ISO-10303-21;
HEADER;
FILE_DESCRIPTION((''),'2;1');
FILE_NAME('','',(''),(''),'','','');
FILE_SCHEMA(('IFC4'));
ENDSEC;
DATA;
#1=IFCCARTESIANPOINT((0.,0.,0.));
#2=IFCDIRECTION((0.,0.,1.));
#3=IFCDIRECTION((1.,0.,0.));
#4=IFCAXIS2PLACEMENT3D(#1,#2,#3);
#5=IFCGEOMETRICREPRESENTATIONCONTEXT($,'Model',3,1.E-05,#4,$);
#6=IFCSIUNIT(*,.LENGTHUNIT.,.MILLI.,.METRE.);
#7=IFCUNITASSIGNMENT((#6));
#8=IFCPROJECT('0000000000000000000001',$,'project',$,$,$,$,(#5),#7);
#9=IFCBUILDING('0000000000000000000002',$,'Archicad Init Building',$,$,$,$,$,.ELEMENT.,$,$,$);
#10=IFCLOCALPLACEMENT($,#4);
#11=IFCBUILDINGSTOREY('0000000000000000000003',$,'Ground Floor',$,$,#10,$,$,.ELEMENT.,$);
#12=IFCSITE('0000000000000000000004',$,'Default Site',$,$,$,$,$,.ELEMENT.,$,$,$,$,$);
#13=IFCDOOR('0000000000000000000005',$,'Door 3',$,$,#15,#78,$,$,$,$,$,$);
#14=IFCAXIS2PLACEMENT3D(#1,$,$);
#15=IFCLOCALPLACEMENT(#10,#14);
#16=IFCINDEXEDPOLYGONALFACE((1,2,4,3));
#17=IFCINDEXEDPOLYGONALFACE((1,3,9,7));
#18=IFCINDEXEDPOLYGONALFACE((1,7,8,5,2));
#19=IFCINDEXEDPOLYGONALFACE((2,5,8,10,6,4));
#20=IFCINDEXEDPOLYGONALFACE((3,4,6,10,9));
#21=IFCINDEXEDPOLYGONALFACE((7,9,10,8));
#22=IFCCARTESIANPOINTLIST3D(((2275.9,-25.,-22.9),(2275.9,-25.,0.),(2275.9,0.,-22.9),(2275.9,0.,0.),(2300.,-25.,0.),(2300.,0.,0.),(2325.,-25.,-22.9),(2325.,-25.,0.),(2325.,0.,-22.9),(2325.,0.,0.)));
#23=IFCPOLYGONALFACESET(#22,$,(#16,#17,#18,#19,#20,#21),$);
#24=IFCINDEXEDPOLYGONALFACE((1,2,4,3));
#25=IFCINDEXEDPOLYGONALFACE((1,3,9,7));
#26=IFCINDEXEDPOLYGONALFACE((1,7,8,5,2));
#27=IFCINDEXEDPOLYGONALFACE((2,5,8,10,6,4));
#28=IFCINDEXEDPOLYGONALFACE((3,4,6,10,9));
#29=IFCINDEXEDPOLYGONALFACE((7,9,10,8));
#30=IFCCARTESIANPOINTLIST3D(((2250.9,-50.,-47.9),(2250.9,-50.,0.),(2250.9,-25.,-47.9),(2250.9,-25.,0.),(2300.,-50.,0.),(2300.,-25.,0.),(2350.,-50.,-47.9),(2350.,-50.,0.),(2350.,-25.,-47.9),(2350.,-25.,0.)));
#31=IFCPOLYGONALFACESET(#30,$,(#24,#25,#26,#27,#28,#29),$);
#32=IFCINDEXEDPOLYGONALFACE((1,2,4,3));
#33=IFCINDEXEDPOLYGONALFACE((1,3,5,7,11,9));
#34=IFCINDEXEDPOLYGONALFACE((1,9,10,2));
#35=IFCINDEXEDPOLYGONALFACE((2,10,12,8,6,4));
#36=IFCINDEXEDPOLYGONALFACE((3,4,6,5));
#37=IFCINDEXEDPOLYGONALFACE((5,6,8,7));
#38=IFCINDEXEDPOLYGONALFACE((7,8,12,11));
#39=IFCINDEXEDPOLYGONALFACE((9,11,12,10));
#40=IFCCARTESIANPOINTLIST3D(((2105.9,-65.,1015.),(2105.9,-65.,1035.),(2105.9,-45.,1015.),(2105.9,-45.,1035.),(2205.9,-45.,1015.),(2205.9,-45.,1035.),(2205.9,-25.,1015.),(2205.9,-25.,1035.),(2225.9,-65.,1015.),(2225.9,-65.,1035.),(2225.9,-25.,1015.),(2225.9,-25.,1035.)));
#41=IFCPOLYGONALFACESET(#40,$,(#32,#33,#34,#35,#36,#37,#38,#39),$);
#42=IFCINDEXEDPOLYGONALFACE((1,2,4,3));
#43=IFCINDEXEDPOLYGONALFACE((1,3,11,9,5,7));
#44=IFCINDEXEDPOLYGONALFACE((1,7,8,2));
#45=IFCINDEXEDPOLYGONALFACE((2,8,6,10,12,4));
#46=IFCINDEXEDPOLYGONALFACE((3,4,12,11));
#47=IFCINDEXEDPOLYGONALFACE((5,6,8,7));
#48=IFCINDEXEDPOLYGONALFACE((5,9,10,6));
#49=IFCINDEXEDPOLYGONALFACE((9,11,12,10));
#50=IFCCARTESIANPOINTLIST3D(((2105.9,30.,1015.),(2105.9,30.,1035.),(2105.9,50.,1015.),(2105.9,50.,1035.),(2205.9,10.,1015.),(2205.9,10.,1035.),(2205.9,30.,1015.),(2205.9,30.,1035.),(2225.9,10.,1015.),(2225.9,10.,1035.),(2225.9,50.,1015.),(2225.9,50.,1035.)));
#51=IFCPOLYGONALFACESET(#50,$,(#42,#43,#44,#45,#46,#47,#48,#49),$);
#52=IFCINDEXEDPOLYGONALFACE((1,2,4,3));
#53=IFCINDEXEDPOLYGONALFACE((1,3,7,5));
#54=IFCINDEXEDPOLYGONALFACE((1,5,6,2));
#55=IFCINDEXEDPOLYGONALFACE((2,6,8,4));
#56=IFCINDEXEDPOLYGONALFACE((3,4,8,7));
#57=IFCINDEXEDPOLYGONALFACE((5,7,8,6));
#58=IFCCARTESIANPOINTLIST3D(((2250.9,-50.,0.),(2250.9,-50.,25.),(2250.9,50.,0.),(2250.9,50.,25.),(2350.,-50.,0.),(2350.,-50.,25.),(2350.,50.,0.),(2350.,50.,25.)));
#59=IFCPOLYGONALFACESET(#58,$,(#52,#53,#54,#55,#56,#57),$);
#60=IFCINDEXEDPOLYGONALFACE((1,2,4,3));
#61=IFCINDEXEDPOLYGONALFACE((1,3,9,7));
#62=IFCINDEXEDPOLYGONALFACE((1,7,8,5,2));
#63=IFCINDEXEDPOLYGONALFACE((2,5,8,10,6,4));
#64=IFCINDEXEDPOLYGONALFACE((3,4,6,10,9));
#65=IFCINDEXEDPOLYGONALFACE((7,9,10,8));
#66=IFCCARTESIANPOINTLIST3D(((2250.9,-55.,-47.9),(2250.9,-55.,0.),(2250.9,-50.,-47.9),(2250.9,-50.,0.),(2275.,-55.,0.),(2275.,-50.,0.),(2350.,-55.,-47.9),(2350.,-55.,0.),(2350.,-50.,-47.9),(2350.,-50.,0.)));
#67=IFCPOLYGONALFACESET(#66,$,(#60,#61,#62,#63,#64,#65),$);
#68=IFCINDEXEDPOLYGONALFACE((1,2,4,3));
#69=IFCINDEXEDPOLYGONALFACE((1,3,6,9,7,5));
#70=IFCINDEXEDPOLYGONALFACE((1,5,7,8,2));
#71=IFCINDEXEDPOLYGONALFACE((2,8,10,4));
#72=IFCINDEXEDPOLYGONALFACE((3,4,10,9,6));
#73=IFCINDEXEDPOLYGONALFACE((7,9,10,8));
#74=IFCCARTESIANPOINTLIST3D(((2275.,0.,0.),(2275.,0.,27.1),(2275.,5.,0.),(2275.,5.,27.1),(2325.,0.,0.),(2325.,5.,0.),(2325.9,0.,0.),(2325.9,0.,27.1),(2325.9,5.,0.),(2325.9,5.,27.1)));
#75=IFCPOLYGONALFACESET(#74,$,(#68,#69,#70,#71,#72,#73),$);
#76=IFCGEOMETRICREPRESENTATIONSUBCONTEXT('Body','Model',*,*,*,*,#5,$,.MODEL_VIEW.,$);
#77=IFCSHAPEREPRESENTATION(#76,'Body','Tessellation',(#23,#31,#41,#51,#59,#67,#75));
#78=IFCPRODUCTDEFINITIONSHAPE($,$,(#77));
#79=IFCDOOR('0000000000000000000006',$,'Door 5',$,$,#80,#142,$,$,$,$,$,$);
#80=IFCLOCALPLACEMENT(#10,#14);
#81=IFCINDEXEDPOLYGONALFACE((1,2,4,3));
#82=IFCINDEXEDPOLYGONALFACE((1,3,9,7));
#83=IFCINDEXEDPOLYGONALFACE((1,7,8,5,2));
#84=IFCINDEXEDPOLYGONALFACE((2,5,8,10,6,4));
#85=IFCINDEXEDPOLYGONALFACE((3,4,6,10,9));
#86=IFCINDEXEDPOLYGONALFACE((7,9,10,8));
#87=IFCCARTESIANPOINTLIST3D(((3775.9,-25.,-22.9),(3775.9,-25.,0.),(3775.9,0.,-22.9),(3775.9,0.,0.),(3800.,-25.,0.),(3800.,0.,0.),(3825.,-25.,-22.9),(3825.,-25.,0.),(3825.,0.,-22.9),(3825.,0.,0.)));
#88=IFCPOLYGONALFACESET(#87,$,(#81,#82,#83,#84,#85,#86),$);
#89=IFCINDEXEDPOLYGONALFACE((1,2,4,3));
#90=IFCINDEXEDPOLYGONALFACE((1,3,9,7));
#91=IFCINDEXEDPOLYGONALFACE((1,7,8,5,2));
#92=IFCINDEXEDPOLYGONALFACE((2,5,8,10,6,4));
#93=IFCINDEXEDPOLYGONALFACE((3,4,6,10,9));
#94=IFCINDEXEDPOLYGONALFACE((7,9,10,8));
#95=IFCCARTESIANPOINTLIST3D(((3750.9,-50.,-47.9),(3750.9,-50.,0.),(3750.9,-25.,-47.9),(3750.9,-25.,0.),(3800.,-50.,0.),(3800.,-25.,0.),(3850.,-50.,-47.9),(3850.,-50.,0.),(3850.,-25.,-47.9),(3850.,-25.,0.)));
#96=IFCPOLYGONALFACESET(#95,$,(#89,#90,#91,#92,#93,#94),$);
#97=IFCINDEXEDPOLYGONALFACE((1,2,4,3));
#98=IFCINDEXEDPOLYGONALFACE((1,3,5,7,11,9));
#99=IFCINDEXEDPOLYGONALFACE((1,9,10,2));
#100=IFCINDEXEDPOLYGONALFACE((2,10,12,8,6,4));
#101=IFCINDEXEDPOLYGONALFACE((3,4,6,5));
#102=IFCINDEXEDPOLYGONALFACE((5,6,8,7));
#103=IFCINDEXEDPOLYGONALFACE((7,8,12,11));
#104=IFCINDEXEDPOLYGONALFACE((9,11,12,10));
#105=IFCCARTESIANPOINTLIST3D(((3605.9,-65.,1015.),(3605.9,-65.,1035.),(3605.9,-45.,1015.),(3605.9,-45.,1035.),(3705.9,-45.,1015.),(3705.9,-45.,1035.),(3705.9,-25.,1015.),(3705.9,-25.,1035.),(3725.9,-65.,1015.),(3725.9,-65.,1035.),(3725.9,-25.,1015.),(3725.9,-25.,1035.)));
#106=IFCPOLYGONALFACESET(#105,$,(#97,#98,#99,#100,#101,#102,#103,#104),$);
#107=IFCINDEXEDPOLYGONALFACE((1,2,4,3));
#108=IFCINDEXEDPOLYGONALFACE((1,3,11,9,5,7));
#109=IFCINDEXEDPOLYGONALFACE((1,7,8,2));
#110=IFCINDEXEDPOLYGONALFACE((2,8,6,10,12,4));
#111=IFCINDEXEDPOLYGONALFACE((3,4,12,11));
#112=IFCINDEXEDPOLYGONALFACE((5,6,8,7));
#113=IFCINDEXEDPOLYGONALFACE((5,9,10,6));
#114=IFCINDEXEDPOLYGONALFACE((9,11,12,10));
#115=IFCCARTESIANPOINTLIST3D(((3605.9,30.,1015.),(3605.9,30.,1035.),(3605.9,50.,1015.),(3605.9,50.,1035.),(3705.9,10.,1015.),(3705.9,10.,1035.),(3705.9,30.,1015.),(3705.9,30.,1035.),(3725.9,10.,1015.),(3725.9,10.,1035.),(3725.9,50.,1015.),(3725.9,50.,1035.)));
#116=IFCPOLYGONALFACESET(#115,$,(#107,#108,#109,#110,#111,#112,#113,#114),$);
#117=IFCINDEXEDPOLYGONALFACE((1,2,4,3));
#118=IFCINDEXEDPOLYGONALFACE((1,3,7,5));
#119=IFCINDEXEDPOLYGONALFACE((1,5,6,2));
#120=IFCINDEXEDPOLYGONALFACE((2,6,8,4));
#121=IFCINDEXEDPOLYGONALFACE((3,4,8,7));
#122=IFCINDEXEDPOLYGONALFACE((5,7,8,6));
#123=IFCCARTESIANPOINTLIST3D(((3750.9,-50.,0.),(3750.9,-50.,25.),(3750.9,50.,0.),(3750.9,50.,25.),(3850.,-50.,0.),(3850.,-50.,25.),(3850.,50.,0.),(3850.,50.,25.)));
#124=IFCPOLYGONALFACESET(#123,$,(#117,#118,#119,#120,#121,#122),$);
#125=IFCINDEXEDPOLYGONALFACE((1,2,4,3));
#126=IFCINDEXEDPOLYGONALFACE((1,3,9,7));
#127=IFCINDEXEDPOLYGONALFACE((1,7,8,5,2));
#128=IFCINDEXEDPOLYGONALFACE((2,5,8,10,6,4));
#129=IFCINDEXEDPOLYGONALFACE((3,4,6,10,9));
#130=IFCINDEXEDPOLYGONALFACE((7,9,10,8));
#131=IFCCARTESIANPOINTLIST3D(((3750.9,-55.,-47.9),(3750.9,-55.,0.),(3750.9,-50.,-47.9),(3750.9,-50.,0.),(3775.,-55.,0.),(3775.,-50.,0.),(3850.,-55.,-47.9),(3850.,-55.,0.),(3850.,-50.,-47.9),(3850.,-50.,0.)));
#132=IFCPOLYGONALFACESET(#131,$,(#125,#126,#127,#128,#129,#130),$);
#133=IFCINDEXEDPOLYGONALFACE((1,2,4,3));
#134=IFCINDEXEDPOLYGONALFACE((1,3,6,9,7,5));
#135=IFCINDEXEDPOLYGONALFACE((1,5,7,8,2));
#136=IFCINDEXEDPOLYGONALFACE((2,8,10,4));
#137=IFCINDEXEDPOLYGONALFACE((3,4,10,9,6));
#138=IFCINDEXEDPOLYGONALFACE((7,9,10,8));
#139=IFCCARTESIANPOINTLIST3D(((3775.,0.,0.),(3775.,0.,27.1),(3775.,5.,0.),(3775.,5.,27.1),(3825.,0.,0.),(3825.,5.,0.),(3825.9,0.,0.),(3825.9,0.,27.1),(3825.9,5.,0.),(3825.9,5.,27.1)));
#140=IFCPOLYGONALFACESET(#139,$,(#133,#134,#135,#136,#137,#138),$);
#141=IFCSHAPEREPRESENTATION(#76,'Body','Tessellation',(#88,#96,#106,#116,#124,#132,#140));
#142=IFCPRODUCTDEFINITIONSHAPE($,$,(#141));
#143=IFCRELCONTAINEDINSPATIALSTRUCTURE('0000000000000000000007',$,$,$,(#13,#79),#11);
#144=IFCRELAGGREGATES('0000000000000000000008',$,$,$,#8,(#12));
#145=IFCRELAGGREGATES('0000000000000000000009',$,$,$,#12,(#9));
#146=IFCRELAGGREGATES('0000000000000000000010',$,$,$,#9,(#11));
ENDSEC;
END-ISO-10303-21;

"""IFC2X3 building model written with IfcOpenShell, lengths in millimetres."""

from ifc_helpers import new_model, si_unit, frame, origin_with_axes, place, context, subcontext, project, spatial, polyline, outline, extrude, element, save


model = new_model("IFC2X3")

# Units and contexts
model_context = context("Model", 3, precision=1e-05, world=origin_with_axes())
body_context = subcontext(model_context, "Body", "Model", "MODEL_VIEW")
ifc_project = project(units=[si_unit("LENGTHUNIT", "METRE", prefix="MILLI")], contexts=[model_context])

# Site, building, storey
site = spatial("IfcSite", under=ifc_project, Name="Default Site", CompositionType="ELEMENT")
building = spatial("IfcBuilding", under=site, Name="Archicad Init Building", CompositionType="ELEMENT")
storey_placement = place(None, origin_with_axes())
storey = spatial("IfcBuildingStorey", under=building, at=storey_placement, Name="Ground Floor", CompositionType="ELEMENT")

# Doors
door_1_placement = place(storey_placement, frame((2300.0, -50.0, 0.0), z_axis=(0.0, 0.0, 1.0), x_axis=(1.0, 0.0, 0.0)))
element("IfcDoor", 1, at=door_1_placement, inside=storey, Name="Door 3", context=body_context, shape_type="SweptSolid", body=[
    extrude(outline(polyline([(0.0, 0.0), (0.0, 2.1), (0.9, 2.1), (0.9, 0.0), (-24.1, 0.0), (-24.1, -22.9), (25.0, -22.9), (25.0, 0.0), (0.0, 0.0)])), frame((0.0, 25.0, 0.0), z_axis=(0.0, -1.0, 0.0), x_axis=(1.0, 0.0, 0.0)), (0.0, 0.0, -1.0), 25.0),
    extrude(outline(polyline([(0.0, 0.0), (0.0, 2.1), (0.9, 2.1), (0.9, 0.0), (-49.1, 0.0), (-49.1, -47.9), (50.0, -47.9), (50.0, 0.0), (0.0, 0.0)])), frame((0.0, 0.0, 0.0), z_axis=(0.0, -1.0, 0.0), x_axis=(1.0, 0.0, 0.0)), (0.0, 0.0, -1.0), 25.0),
    extrude(outline(polyline([(0.0, 0.0), (-49.1, 0.0), (-49.1, 35.0), (0.0, 35.0), (0.0, 0.0)])), frame((25.0, 25.0, 25.0), z_axis=(0.0, 0.0, 1.0), x_axis=(1.0, 0.0, 0.0)), (0.0, 0.0, 1.0), -47.9),
    extrude(outline(polyline([(0.0, 0.0), (0.0, -40.0), (-120.0, -40.0), (-120.0, -20.0), (-20.0, -20.0), (-20.0, 0.0), (0.0, 0.0)])), frame((-74.1, 25.0, 1015.0), z_axis=(0.0, 0.0, 1.0), x_axis=(1.0, 0.0, 0.0)), (0.0, 0.0, 1.0), 20.0),
    extrude(outline(polyline([(0.0, 0.0), (0.0, 40.0), (-120.0, 40.0), (-120.0, 20.0), (-20.0, 20.0), (-20.0, 0.0), (0.0, 0.0)])), frame((-74.1, 60.0, 1015.0), z_axis=(0.0, 0.0, 1.0), x_axis=(1.0, 0.0, 0.0)), (0.0, 0.0, 1.0), 20.0),
    extrude(outline(polyline([(0.0, 0.0), (-99.1, 0.0), (-99.1, 100.0), (0.0, 100.0), (0.0, 0.0)])), frame((50.0, 0.0, 0.0), z_axis=(0.0, 0.0, 1.0), x_axis=(1.0, 0.0, 0.0)), (0.0, 0.0, 1.0), 25.0),
    extrude(outline(polyline([(0.0, 0.0), (0.0, 27.1), (50.9, 27.1), (50.9, 0.0), (-24.1, 0.0), (-24.1, -47.9), (75.0, -47.9), (75.0, 0.0), (0.0, 0.0)])), frame((-25.0, -5.0, 0.0), z_axis=(0.0, -1.0, 0.0), x_axis=(1.0, 0.0, 0.0)), (0.0, 0.0, -1.0), 5.0),
    extrude(outline(polyline([(0.0, 0.0), (0.0, 27.1), (50.9, 27.1), (50.9, 0.0), (0.9, 0.0), (0.9, -22.9), (50.0, -22.9), (50.0, 0.0), (0.0, 0.0)])), frame((-25.0, 50.0, 0.0), z_axis=(0.0, -1.0, 0.0), x_axis=(1.0, 0.0, 0.0)), (0.0, 0.0, -1.0), 5.0),
])
door_2_placement = place(storey_placement, frame((3800.0, -50.0, 0.0), z_axis=(0.0, 0.0, 1.0), x_axis=(1.0, 0.0, 0.0)))
element("IfcDoor", 2, at=door_2_placement, inside=storey, Name="Door 5", context=body_context, shape_type="SweptSolid", body=[
    extrude(outline(polyline([(0.0, 0.0), (0.0, 2.1), (0.9, 2.1), (0.9, 0.0), (-24.1, 0.0), (-24.1, -22.9), (25.0, -22.9), (25.0, 0.0), (0.0, 0.0)])), frame((0.0, 25.0, 0.0), z_axis=(0.0, -1.0, 0.0), x_axis=(1.0, 0.0, 0.0)), (0.0, 0.0, -1.0), 25.0),
    extrude(outline(polyline([(0.0, 0.0), (0.0, 2.1), (0.9, 2.1), (0.9, 0.0), (-49.1, 0.0), (-49.1, -47.9), (50.0, -47.9), (50.0, 0.0), (0.0, 0.0)])), frame((0.0, 0.0, 0.0), z_axis=(0.0, -1.0, 0.0), x_axis=(1.0, 0.0, 0.0)), (0.0, 0.0, -1.0), 25.0),
    extrude(outline(polyline([(0.0, 0.0), (-49.1, 0.0), (-49.1, 35.0), (0.0, 35.0), (0.0, 0.0)])), frame((25.0, 25.0, 25.0), z_axis=(0.0, 0.0, 1.0), x_axis=(1.0, 0.0, 0.0)), (0.0, 0.0, 1.0), -47.9),
    extrude(outline(polyline([(0.0, 0.0), (0.0, -40.0), (-120.0, -40.0), (-120.0, -20.0), (-20.0, -20.0), (-20.0, 0.0), (0.0, 0.0)])), frame((-74.1, 25.0, 1015.0), z_axis=(0.0, 0.0, 1.0), x_axis=(1.0, 0.0, 0.0)), (0.0, 0.0, 1.0), 20.0),
    extrude(outline(polyline([(0.0, 0.0), (0.0, 40.0), (-120.0, 40.0), (-120.0, 20.0), (-20.0, 20.0), (-20.0, 0.0), (0.0, 0.0)])), frame((-74.1, 60.0, 1015.0), z_axis=(0.0, 0.0, 1.0), x_axis=(1.0, 0.0, 0.0)), (0.0, 0.0, 1.0), 20.0),
    extrude(outline(polyline([(0.0, 0.0), (-99.1, 0.0), (-99.1, 100.0), (0.0, 100.0), (0.0, 0.0)])), frame((50.0, 0.0, 0.0), z_axis=(0.0, 0.0, 1.0), x_axis=(1.0, 0.0, 0.0)), (0.0, 0.0, 1.0), 25.0),
    extrude(outline(polyline([(0.0, 0.0), (0.0, 27.1), (50.9, 27.1), (50.9, 0.0), (-24.1, 0.0), (-24.1, -47.9), (75.0, -47.9), (75.0, 0.0), (0.0, 0.0)])), frame((-25.0, -5.0, 0.0), z_axis=(0.0, -1.0, 0.0), x_axis=(1.0, 0.0, 0.0)), (0.0, 0.0, -1.0), 5.0),
    extrude(outline(polyline([(0.0, 0.0), (0.0, 27.1), (50.9, 27.1), (50.9, 0.0), (0.9, 0.0), (0.9, -22.9), (50.0, -22.9), (50.0, 0.0), (0.0, 0.0)])), frame((-25.0, 50.0, 0.0), z_axis=(0.0, -1.0, 0.0), x_axis=(1.0, 0.0, 0.0)), (0.0, 0.0, -1.0), 5.0),
])

save(model, "model.ifc")
